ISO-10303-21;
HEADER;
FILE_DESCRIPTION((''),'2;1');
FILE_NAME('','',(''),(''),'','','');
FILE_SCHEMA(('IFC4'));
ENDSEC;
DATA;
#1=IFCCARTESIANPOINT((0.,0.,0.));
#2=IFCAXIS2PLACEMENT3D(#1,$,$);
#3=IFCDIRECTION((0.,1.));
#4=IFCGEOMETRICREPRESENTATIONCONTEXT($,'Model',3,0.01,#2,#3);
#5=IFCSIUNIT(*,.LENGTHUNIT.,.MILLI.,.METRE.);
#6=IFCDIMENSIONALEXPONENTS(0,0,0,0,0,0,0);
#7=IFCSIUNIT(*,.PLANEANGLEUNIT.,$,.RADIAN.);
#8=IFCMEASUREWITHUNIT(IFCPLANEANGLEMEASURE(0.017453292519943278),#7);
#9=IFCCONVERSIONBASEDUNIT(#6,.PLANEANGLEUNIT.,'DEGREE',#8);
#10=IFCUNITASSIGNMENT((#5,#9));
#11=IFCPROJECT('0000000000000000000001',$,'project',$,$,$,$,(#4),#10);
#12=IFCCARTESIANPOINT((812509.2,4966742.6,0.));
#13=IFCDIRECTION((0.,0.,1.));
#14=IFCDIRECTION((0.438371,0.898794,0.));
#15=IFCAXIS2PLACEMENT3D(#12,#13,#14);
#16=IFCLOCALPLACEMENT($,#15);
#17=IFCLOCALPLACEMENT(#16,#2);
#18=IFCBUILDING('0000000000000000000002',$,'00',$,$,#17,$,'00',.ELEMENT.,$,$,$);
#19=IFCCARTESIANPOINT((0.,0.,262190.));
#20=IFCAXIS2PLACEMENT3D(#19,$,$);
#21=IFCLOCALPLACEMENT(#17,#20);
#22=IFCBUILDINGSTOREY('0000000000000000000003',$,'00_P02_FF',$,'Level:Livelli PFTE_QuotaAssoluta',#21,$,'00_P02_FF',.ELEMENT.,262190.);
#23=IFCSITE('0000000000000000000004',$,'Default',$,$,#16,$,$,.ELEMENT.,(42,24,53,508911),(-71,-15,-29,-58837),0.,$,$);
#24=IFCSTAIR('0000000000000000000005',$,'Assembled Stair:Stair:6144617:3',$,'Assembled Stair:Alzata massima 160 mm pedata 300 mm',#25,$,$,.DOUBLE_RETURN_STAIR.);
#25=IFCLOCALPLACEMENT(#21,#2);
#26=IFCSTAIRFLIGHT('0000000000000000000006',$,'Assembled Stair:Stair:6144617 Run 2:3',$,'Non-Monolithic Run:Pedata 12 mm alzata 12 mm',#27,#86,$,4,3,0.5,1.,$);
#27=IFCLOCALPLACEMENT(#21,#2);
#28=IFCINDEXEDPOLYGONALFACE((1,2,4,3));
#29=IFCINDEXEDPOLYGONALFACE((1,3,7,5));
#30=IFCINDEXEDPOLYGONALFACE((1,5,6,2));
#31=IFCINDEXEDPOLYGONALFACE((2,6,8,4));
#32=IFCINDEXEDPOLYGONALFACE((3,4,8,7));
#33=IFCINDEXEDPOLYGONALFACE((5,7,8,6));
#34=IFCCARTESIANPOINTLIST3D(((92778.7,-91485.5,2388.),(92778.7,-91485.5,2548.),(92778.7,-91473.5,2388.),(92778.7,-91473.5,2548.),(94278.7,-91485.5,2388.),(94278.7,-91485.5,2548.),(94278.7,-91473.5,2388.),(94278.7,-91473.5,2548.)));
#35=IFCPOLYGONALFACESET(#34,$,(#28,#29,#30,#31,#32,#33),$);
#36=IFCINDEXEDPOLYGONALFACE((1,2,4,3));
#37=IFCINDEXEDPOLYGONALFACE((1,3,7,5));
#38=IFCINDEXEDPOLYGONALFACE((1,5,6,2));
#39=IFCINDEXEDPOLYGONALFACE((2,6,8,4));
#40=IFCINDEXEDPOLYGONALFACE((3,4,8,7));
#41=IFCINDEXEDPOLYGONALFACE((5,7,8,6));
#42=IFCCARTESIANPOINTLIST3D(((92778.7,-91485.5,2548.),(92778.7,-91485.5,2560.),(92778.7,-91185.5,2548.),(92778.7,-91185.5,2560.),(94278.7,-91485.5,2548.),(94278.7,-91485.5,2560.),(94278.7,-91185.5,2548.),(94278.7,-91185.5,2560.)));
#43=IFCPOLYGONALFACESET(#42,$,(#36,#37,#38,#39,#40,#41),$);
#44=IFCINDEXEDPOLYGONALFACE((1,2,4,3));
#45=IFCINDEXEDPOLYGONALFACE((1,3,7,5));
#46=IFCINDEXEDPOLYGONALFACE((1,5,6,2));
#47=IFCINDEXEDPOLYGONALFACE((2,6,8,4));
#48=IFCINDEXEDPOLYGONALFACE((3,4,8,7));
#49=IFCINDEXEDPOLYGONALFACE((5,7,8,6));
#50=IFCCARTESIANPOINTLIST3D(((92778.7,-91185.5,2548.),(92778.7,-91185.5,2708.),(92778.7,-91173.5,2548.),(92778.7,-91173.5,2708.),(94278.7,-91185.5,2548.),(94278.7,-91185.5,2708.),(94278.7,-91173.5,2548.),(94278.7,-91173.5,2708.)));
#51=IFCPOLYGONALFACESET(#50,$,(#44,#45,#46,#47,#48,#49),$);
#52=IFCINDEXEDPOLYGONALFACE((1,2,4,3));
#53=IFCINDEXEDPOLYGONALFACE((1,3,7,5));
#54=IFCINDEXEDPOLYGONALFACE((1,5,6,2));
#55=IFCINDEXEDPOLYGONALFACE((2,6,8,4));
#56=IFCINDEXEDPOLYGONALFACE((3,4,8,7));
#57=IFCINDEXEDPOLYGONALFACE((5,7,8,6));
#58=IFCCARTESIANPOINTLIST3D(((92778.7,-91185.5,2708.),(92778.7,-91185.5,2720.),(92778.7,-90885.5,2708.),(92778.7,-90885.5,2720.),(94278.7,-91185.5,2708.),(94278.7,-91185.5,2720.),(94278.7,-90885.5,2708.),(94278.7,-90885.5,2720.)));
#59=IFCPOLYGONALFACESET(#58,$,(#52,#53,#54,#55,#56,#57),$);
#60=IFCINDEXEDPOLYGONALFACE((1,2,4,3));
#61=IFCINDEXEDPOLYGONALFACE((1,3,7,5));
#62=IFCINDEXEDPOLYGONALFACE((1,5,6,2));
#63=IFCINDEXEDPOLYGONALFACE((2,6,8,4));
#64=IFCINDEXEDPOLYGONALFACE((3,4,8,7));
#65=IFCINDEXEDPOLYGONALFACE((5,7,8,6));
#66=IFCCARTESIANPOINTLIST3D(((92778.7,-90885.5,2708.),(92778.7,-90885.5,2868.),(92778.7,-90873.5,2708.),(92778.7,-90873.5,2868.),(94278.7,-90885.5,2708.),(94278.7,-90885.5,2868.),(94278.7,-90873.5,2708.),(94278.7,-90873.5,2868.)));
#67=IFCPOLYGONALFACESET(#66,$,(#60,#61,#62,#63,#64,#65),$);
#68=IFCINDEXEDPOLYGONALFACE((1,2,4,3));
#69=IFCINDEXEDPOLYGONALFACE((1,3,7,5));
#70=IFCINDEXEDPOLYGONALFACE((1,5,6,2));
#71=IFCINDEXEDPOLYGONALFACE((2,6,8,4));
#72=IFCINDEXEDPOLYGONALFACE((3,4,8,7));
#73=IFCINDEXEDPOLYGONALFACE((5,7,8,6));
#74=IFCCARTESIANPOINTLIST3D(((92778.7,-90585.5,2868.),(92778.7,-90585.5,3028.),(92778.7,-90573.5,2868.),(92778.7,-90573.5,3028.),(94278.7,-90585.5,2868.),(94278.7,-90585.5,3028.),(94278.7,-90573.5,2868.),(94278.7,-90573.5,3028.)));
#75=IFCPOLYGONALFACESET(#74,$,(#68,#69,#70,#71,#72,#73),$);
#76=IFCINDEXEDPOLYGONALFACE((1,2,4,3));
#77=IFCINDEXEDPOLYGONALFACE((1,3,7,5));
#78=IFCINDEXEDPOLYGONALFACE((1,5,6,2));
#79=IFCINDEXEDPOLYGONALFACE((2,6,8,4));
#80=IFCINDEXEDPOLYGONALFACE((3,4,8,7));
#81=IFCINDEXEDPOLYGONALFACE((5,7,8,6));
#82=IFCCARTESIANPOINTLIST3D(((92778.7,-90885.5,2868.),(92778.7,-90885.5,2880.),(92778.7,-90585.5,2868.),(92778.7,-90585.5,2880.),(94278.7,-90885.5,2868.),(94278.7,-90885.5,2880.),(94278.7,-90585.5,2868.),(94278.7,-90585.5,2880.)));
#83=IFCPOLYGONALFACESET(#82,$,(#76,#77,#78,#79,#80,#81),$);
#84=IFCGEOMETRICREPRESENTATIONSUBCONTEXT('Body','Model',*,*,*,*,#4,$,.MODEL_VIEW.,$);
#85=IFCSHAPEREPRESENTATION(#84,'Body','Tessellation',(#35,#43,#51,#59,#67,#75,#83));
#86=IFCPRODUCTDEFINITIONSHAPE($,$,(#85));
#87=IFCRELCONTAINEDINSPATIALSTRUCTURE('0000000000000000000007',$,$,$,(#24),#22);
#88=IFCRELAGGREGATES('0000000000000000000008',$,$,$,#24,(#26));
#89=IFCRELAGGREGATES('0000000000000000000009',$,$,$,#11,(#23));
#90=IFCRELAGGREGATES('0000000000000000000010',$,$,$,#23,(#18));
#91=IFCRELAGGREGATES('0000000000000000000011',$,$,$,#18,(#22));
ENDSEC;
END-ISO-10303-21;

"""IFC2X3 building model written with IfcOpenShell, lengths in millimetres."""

from ifc_helpers import new_model, entity, si_unit, converted_unit, direction, frame, frame_2d, origin, origin_2d_with_axis, place, context, subcontext, project, spatial, rectangle, extrude, element, aggregate, save


model = new_model("IFC2X3")

# Units and contexts
model_context = context("Model", 3, precision=0.01, world=origin(), true_north=direction((0.0, 1.0)))
body_context = subcontext(model_context, "Body", "Model", "MODEL_VIEW")
ifc_project = project(units=[si_unit("LENGTHUNIT", "METRE", prefix="MILLI"), converted_unit("PLANEANGLEUNIT", "DEGREE", entity("IfcPlaneAngleMeasure", 0.017453292519943278), si_unit("PLANEANGLEUNIT", "RADIAN"), dimensions=[0, 0, 0, 0, 0, 0, 0])], contexts=[model_context])

# Site, building, storey
site_placement = place(None, frame((812509.2, 4966742.6, 0.0), z_axis=(0.0, 0.0, 1.0), x_axis=(0.438371, 0.898794, 0.0)))
site = spatial("IfcSite", under=ifc_project, at=site_placement, Name="Default", CompositionType="ELEMENT", RefLatitude=(42, 24, 53, 508911), RefLongitude=(-71, -15, -29, -58837), RefElevation=0.0)
building_placement = place(site_placement, origin())
building = spatial("IfcBuilding", under=site, at=building_placement, Name="00", LongName="00", CompositionType="ELEMENT")
storey_placement = place(building_placement, frame((0.0, 0.0, 262190.0)))
storey = spatial("IfcBuildingStorey", under=building, at=storey_placement, Name="00_P02_FF", ObjectType="Level:Livelli PFTE_QuotaAssoluta", LongName="00_P02_FF", CompositionType="ELEMENT", Elevation=262190.0)

# Stair
stair_1_placement = place(storey_placement, origin())
stair_1 = element("IfcStair", 1, at=stair_1_placement, inside=storey, Name="Assembled Stair:Stair:6144617:3", ObjectType="Assembled Stair:Alzata massima 160 mm pedata 300 mm", ShapeType="DOUBLE_RETURN_STAIR")

# Stair flight
stair_flight_1_placement = place(stair_1_placement, origin())
stair_flight_1 = element("IfcStairFlight", 2, at=stair_flight_1_placement, Name="Assembled Stair:Stair:6144617 Run 2:3", ObjectType="Non-Monolithic Run:Pedata 12 mm alzata 12 mm", NumberOfRiser=4, NumberOfTreads=3, RiserHeight=0.5, TreadLength=1.0, context=body_context, shape_type="SweptSolid", body=[
    extrude(rectangle(XDim=1500.0, YDim=12.0, at=origin_2d_with_axis()), frame((93528.7, -91479.5, 2388.0), z_axis=(0.0, 0.0, 1.0), x_axis=(-1.0, 0.0, 0.0)), (0.0, 0.0, 1.0), 160.0),
    extrude(rectangle(XDim=300.0, YDim=1500.0, at=frame_2d((0.0, 0.0), x_axis=(1.0, 0.0))), frame((93528.7, -91335.5, 2548.0), z_axis=(0.0, 0.0, 1.0), x_axis=(0.0, -1.0, 0.0)), (0.0, 0.0, 1.0), 12.0),
    extrude(rectangle(XDim=1500.0, YDim=12.0, at=frame_2d((0.0, 0.0), x_axis=(1.0, 0.0))), frame((93528.7, -91179.5, 2548.0), z_axis=(0.0, 0.0, 1.0), x_axis=(-1.0, 0.0, 0.0)), (0.0, 0.0, 1.0), 160.0),
    extrude(rectangle(XDim=300.0, YDim=1500.0, at=origin_2d_with_axis()), frame((93528.7, -91035.5, 2708.0), z_axis=(0.0, 0.0, 1.0), x_axis=(0.0, -1.0, 0.0)), (0.0, 0.0, 1.0), 12.0),
    extrude(rectangle(XDim=1500.0, YDim=12.0, at=frame_2d((0.0, 0.0), x_axis=(1.0, 0.0))), frame((93528.7, -90879.5, 2708.0), z_axis=(0.0, 0.0, 1.0), x_axis=(-1.0, 0.0, 0.0)), (0.0, 0.0, 1.0), 160.0),
    extrude(rectangle(XDim=1500.0, YDim=12.0, at=origin_2d_with_axis()), frame((93528.7, -90579.5, 2868.0), z_axis=(0.0, 0.0, 1.0), x_axis=(-1.0, 0.0, 0.0)), (0.0, 0.0, 1.0), 160.0),
    extrude(rectangle(XDim=300.0, YDim=1500.0, at=origin_2d_with_axis()), frame((93528.7, -90735.5, 2868.0), z_axis=(0.0, 0.0, 1.0), x_axis=(0.0, -1.0, 0.0)), (0.0, 0.0, 1.0), 12.0),
])
aggregate(stair_1, [stair_flight_1])

save(model, "model.ifc")
